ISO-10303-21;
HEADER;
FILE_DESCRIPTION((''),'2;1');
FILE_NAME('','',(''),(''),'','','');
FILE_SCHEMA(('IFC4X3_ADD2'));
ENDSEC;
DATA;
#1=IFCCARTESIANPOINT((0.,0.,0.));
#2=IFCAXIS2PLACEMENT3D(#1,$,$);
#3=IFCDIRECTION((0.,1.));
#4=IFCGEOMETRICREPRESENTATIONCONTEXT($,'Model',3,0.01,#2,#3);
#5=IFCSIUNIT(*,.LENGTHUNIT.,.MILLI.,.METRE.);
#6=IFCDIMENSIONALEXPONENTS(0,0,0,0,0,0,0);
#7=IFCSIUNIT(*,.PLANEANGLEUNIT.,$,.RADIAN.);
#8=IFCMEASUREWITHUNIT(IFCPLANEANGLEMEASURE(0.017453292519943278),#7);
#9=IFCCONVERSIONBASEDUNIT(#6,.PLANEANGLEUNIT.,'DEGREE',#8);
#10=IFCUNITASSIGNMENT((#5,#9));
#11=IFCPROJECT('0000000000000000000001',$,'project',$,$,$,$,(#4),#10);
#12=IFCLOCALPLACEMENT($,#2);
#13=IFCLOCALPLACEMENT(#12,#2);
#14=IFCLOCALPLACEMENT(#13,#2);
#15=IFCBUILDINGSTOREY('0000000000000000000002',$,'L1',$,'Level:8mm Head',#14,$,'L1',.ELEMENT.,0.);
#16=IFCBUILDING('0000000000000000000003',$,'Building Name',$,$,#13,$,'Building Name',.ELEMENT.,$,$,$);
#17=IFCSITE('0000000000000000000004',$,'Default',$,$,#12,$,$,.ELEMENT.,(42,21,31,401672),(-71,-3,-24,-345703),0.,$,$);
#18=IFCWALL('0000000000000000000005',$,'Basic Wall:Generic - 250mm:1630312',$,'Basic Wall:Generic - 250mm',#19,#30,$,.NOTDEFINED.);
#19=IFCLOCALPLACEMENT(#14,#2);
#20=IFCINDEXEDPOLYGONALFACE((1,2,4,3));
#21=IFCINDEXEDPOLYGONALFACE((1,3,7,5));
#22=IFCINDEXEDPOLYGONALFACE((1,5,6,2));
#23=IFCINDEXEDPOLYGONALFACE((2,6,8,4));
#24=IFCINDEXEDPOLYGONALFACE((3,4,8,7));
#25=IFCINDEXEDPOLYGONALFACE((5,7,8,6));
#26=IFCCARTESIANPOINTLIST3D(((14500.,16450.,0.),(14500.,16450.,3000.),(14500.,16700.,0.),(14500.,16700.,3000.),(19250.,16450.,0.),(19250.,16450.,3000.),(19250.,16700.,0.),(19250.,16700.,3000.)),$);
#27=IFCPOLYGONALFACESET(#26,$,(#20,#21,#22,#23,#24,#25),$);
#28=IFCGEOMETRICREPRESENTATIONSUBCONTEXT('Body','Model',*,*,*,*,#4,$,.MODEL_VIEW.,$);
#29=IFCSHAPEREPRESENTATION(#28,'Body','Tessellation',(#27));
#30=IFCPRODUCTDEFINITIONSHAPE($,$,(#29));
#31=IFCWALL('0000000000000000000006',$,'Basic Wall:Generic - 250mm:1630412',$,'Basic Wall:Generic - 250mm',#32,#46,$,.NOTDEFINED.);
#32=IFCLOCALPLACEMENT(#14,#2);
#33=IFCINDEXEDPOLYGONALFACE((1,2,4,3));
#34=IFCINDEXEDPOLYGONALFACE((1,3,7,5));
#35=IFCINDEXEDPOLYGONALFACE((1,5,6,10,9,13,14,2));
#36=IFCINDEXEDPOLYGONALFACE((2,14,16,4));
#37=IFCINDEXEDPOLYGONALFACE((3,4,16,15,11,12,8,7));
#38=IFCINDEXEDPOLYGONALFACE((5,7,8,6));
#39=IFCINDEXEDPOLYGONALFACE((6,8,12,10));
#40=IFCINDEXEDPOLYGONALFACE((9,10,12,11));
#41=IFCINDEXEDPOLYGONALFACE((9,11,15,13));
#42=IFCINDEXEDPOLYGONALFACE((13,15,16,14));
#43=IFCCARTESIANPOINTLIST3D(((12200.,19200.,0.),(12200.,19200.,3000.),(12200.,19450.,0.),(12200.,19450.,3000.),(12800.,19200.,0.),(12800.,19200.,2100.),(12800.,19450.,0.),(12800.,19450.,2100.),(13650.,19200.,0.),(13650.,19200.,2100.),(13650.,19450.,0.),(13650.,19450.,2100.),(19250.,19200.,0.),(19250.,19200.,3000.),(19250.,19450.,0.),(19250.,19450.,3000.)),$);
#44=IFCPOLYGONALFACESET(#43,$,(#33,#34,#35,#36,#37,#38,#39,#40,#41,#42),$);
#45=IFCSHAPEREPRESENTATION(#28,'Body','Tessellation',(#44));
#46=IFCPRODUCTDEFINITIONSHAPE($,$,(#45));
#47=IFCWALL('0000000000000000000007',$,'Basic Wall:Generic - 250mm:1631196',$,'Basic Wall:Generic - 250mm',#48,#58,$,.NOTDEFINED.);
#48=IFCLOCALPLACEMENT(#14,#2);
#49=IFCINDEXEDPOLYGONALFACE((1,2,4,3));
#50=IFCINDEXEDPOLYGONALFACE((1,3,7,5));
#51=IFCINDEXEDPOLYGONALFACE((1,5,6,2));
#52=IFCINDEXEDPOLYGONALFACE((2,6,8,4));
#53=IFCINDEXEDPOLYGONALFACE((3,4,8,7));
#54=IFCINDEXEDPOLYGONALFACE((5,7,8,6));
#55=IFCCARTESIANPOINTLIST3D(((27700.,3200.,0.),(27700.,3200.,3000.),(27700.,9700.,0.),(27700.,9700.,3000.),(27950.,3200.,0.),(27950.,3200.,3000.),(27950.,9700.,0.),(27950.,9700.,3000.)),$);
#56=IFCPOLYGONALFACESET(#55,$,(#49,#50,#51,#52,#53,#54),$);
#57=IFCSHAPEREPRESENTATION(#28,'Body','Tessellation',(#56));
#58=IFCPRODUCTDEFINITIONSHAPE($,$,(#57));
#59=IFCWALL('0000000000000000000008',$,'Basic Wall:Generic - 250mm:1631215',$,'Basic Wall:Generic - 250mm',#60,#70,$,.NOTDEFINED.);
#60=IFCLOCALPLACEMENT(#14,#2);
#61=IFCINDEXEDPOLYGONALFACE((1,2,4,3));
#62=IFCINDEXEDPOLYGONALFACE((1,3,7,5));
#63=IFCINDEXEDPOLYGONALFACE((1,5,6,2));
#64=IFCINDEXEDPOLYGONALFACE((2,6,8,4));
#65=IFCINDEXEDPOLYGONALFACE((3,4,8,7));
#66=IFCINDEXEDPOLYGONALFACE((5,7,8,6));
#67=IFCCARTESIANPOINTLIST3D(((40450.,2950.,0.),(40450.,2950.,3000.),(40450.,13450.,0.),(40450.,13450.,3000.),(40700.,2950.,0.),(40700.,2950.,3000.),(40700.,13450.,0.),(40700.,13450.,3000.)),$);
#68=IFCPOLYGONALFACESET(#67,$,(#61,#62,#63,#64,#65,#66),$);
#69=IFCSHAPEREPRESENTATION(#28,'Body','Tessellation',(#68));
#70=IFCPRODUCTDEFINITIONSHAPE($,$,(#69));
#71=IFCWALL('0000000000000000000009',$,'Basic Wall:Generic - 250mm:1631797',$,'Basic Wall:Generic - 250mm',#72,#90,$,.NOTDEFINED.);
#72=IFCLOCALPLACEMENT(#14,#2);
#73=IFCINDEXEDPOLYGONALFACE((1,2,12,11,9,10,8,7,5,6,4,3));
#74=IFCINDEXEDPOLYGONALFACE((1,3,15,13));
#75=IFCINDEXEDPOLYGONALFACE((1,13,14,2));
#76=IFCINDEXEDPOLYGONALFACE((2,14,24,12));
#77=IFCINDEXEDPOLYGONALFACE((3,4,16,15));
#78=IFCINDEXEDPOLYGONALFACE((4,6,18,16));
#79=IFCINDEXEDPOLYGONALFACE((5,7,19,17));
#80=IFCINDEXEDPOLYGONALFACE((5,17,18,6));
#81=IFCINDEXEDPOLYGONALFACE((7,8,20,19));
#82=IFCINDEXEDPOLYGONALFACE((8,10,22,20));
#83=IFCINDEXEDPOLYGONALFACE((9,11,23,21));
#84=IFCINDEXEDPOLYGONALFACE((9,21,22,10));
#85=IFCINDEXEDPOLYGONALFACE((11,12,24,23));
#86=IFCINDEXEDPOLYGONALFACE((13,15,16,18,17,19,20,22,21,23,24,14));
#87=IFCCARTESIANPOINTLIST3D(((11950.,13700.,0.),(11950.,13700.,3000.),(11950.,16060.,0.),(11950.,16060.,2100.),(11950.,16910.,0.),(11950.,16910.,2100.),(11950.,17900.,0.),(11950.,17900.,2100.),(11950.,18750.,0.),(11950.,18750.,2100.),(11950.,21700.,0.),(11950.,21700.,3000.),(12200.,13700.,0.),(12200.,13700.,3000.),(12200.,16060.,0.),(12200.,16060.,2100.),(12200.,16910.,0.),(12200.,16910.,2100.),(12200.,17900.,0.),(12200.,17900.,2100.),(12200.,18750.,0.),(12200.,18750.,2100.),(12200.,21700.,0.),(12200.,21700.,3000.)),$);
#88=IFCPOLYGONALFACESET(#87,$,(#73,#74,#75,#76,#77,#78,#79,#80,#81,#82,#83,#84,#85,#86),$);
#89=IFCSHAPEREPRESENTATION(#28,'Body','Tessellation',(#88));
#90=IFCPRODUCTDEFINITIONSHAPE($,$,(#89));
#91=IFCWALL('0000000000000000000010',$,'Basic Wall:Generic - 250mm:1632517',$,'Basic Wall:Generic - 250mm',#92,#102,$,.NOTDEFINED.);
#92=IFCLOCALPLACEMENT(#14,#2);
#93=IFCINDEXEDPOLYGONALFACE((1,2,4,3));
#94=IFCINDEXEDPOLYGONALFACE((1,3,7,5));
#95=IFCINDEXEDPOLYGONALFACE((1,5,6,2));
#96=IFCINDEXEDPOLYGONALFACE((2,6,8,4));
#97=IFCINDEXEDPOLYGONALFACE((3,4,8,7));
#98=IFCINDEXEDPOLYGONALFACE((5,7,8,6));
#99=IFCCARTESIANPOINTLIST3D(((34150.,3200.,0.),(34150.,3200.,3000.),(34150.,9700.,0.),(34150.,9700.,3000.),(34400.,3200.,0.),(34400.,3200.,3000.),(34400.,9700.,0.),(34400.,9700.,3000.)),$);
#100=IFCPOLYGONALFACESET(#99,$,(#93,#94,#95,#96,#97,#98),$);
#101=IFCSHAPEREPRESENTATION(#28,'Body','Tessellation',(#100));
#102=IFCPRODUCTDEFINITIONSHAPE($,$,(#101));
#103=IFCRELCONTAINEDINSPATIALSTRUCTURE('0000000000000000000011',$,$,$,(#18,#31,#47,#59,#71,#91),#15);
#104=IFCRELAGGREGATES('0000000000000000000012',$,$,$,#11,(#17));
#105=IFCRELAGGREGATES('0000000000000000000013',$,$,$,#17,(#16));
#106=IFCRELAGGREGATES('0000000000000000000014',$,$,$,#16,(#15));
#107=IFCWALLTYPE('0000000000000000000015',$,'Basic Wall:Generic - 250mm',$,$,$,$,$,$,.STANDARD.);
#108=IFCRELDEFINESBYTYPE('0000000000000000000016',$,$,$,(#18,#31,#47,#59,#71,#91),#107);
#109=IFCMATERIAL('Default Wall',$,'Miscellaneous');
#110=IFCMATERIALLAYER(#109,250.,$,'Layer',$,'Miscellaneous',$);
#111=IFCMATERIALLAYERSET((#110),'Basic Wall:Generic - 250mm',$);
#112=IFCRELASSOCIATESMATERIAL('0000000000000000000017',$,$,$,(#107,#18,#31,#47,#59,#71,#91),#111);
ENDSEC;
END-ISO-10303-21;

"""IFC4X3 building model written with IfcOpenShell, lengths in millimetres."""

from ifc_helpers import new_model, entity, si_unit, converted_unit, direction, frame, frame_2d, origin, place, context, subcontext, project, spatial, rectangle, extrude, material, layer, layer_set, type_object, element, save


model = new_model("IFC4X3")

# Units and contexts
model_context = context("Model", 3, precision=0.01, world=origin(), true_north=direction((0.0, 1.0)))
body_context = subcontext(model_context, "Body", "Model", "MODEL_VIEW")
ifc_project = project(units=[si_unit("LENGTHUNIT", "METRE", prefix="MILLI"), converted_unit("PLANEANGLEUNIT", "DEGREE", entity("IfcPlaneAngleMeasure", 0.017453292519943278), si_unit("PLANEANGLEUNIT", "RADIAN"), dimensions=[0, 0, 0, 0, 0, 0, 0])], contexts=[model_context])

# Site, building, storey
site_placement = place(None, origin())
site = spatial("IfcSite", under=ifc_project, at=site_placement, Name="Default", CompositionType="ELEMENT", RefLatitude=(42, 21, 31, 401672), RefLongitude=(-71, -3, -24, -345703), RefElevation=0.0)
building_placement = place(site_placement, origin())
building = spatial("IfcBuilding", under=site, at=building_placement, Name="Building Name", LongName="Building Name", CompositionType="ELEMENT")
storey_placement = place(building_placement, origin())
storey = spatial("IfcBuildingStorey", under=building, at=storey_placement, Name="L1", ObjectType="Level:8mm Head", LongName="L1", CompositionType="ELEMENT", Elevation=0.0)

# Shared definitions
ifc_material = material(Name="Default Wall", Category="Miscellaneous")
ifc_layer = layer(ifc_material, 250.0, Name="Layer", Category="Miscellaneous")
ifc_layer_set = layer_set([ifc_layer], Name="Basic Wall:Generic - 250mm")
wall_type = type_object("IfcWallType", Name="Basic Wall:Generic - 250mm", PredefinedType="STANDARD", material=ifc_layer_set)

# Wall
wall_1_placement = place(storey_placement, frame((14500.0, 16575.0, 0.0)))
element("IfcWall", 1, at=wall_1_placement, inside=storey, type_object=wall_type, material=ifc_layer_set, Name="Basic Wall:Generic - 250mm:1630312", ObjectType="Basic Wall:Generic - 250mm", PredefinedType="NOTDEFINED", context=body_context, shape_type="SweptSolid", body=[
    extrude(rectangle(XDim=4750.0, YDim=250.0, at=frame_2d((2375.0, 0.0), x_axis=(-1.0, 0.0))), origin(), (0.0, 0.0, 1.0), 3000.0),
])

# Wall, opening
wall_2_placement = place(storey_placement, frame((12200.0, 19325.0, 0.0)))
wall_2 = element("IfcWall", 2, at=wall_2_placement, inside=storey, type_object=wall_type, material=ifc_layer_set, Name="Basic Wall:Generic - 250mm:1630412", ObjectType="Basic Wall:Generic - 250mm", PredefinedType="NOTDEFINED", context=body_context, shape_type="SweptSolid", body=[
    extrude(rectangle(XDim=7050.0, YDim=250.0, at=frame_2d((3525.0, 0.0), x_axis=(-1.0, 0.0))), origin(), (0.0, 0.0, 1.0), 3000.0),
])
opening_1_placement = place(wall_2_placement, frame((600.0, -125.0, 0.0)))
element("IfcOpeningElement", 3, at=opening_1_placement, cuts=wall_2, PredefinedType="OPENING", context=body_context, shape_type="SweptSolid", body=[
    extrude(rectangle(XDim=2100.0, YDim=850.0, at=frame_2d((1050.0, 425.0), x_axis=(1.0, 0.0))), frame((0.0, 0.0, 0.0), z_axis=(0.0, 1.0, 0.0), x_axis=(0.0, 0.0, 1.0)), (0.0, 0.0, 1.0), 250.0),
])

# Walls
wall_3_placement = place(storey_placement, frame((27825.0, 3200.0, 0.0), z_axis=(0.0, 0.0, 1.0), x_axis=(0.0, 1.0, 0.0)))
element("IfcWall", 4, at=wall_3_placement, inside=storey, type_object=wall_type, material=ifc_layer_set, Name="Basic Wall:Generic - 250mm:1631196", ObjectType="Basic Wall:Generic - 250mm", PredefinedType="NOTDEFINED", context=body_context, shape_type="SweptSolid", body=[
    extrude(rectangle(XDim=6500.0, YDim=250.0, at=frame_2d((3250.0, 0.0), x_axis=(-1.0, 0.0))), origin(), (0.0, 0.0, 1.0), 3000.0),
])
wall_4_placement = place(storey_placement, frame((40575.0, 2950.0, 0.0), z_axis=(0.0, 0.0, 1.0), x_axis=(0.0, 1.0, 0.0)))
element("IfcWall", 5, at=wall_4_placement, inside=storey, type_object=wall_type, material=ifc_layer_set, Name="Basic Wall:Generic - 250mm:1631215", ObjectType="Basic Wall:Generic - 250mm", PredefinedType="NOTDEFINED", context=body_context, shape_type="SweptSolid", body=[
    extrude(rectangle(XDim=10500.0, YDim=250.0, at=frame_2d((5250.0, 0.0), x_axis=(-1.0, 0.0))), origin(), (0.0, 0.0, 1.0), 3000.0),
])

# Wall, openings
wall_5_placement = place(storey_placement, frame((12075.0, 13700.0, 0.0), z_axis=(0.0, 0.0, 1.0), x_axis=(0.0, 1.0, 0.0)))
wall_5 = element("IfcWall", 6, at=wall_5_placement, inside=storey, type_object=wall_type, material=ifc_layer_set, Name="Basic Wall:Generic - 250mm:1631797", ObjectType="Basic Wall:Generic - 250mm", PredefinedType="NOTDEFINED", context=body_context, shape_type="SweptSolid", body=[
    extrude(rectangle(XDim=8000.0, YDim=250.0, at=frame_2d((4000.0, 0.0), x_axis=(-1.0, 0.0))), origin(), (0.0, 0.0, 1.0), 3000.0),
])
opening_2_placement = place(wall_5_placement, frame((4200.0, -125.0, 0.0)))
element("IfcOpeningElement", 7, at=opening_2_placement, cuts=wall_5, PredefinedType="OPENING", context=body_context, shape_type="SweptSolid", body=[
    extrude(rectangle(XDim=2100.0, YDim=850.0, at=frame_2d((1050.0, 425.0), x_axis=(1.0, 0.0))), frame((0.0, 0.0, 0.0), z_axis=(0.0, 1.0, 0.0), x_axis=(0.0, 0.0, 1.0)), (0.0, 0.0, 1.0), 250.0),
])
opening_3_placement = place(wall_5_placement, frame((2360.0, -125.0, 0.0)))
element("IfcOpeningElement", 8, at=opening_3_placement, cuts=wall_5, PredefinedType="OPENING", context=body_context, shape_type="SweptSolid", body=[
    extrude(rectangle(XDim=2100.0, YDim=850.0, at=frame_2d((1050.0, 425.0), x_axis=(1.0, 0.0))), frame((0.0, 0.0, 0.0), z_axis=(0.0, 1.0, 0.0), x_axis=(0.0, 0.0, 1.0)), (0.0, 0.0, 1.0), 250.0),
])

# Wall
wall_6_placement = place(storey_placement, frame((34275.0, 9700.0, 0.0), z_axis=(0.0, 0.0, 1.0), x_axis=(0.0, -1.0, 0.0)))
element("IfcWall", 9, at=wall_6_placement, inside=storey, type_object=wall_type, material=ifc_layer_set, Name="Basic Wall:Generic - 250mm:1632517", ObjectType="Basic Wall:Generic - 250mm", PredefinedType="NOTDEFINED", context=body_context, shape_type="SweptSolid", body=[
    extrude(rectangle(XDim=6500.0, YDim=250.0, at=frame_2d((3250.0, 0.0), x_axis=(-1.0, 0.0))), origin(), (0.0, 0.0, 1.0), 3000.0),
])

save(model, "model.ifc")
